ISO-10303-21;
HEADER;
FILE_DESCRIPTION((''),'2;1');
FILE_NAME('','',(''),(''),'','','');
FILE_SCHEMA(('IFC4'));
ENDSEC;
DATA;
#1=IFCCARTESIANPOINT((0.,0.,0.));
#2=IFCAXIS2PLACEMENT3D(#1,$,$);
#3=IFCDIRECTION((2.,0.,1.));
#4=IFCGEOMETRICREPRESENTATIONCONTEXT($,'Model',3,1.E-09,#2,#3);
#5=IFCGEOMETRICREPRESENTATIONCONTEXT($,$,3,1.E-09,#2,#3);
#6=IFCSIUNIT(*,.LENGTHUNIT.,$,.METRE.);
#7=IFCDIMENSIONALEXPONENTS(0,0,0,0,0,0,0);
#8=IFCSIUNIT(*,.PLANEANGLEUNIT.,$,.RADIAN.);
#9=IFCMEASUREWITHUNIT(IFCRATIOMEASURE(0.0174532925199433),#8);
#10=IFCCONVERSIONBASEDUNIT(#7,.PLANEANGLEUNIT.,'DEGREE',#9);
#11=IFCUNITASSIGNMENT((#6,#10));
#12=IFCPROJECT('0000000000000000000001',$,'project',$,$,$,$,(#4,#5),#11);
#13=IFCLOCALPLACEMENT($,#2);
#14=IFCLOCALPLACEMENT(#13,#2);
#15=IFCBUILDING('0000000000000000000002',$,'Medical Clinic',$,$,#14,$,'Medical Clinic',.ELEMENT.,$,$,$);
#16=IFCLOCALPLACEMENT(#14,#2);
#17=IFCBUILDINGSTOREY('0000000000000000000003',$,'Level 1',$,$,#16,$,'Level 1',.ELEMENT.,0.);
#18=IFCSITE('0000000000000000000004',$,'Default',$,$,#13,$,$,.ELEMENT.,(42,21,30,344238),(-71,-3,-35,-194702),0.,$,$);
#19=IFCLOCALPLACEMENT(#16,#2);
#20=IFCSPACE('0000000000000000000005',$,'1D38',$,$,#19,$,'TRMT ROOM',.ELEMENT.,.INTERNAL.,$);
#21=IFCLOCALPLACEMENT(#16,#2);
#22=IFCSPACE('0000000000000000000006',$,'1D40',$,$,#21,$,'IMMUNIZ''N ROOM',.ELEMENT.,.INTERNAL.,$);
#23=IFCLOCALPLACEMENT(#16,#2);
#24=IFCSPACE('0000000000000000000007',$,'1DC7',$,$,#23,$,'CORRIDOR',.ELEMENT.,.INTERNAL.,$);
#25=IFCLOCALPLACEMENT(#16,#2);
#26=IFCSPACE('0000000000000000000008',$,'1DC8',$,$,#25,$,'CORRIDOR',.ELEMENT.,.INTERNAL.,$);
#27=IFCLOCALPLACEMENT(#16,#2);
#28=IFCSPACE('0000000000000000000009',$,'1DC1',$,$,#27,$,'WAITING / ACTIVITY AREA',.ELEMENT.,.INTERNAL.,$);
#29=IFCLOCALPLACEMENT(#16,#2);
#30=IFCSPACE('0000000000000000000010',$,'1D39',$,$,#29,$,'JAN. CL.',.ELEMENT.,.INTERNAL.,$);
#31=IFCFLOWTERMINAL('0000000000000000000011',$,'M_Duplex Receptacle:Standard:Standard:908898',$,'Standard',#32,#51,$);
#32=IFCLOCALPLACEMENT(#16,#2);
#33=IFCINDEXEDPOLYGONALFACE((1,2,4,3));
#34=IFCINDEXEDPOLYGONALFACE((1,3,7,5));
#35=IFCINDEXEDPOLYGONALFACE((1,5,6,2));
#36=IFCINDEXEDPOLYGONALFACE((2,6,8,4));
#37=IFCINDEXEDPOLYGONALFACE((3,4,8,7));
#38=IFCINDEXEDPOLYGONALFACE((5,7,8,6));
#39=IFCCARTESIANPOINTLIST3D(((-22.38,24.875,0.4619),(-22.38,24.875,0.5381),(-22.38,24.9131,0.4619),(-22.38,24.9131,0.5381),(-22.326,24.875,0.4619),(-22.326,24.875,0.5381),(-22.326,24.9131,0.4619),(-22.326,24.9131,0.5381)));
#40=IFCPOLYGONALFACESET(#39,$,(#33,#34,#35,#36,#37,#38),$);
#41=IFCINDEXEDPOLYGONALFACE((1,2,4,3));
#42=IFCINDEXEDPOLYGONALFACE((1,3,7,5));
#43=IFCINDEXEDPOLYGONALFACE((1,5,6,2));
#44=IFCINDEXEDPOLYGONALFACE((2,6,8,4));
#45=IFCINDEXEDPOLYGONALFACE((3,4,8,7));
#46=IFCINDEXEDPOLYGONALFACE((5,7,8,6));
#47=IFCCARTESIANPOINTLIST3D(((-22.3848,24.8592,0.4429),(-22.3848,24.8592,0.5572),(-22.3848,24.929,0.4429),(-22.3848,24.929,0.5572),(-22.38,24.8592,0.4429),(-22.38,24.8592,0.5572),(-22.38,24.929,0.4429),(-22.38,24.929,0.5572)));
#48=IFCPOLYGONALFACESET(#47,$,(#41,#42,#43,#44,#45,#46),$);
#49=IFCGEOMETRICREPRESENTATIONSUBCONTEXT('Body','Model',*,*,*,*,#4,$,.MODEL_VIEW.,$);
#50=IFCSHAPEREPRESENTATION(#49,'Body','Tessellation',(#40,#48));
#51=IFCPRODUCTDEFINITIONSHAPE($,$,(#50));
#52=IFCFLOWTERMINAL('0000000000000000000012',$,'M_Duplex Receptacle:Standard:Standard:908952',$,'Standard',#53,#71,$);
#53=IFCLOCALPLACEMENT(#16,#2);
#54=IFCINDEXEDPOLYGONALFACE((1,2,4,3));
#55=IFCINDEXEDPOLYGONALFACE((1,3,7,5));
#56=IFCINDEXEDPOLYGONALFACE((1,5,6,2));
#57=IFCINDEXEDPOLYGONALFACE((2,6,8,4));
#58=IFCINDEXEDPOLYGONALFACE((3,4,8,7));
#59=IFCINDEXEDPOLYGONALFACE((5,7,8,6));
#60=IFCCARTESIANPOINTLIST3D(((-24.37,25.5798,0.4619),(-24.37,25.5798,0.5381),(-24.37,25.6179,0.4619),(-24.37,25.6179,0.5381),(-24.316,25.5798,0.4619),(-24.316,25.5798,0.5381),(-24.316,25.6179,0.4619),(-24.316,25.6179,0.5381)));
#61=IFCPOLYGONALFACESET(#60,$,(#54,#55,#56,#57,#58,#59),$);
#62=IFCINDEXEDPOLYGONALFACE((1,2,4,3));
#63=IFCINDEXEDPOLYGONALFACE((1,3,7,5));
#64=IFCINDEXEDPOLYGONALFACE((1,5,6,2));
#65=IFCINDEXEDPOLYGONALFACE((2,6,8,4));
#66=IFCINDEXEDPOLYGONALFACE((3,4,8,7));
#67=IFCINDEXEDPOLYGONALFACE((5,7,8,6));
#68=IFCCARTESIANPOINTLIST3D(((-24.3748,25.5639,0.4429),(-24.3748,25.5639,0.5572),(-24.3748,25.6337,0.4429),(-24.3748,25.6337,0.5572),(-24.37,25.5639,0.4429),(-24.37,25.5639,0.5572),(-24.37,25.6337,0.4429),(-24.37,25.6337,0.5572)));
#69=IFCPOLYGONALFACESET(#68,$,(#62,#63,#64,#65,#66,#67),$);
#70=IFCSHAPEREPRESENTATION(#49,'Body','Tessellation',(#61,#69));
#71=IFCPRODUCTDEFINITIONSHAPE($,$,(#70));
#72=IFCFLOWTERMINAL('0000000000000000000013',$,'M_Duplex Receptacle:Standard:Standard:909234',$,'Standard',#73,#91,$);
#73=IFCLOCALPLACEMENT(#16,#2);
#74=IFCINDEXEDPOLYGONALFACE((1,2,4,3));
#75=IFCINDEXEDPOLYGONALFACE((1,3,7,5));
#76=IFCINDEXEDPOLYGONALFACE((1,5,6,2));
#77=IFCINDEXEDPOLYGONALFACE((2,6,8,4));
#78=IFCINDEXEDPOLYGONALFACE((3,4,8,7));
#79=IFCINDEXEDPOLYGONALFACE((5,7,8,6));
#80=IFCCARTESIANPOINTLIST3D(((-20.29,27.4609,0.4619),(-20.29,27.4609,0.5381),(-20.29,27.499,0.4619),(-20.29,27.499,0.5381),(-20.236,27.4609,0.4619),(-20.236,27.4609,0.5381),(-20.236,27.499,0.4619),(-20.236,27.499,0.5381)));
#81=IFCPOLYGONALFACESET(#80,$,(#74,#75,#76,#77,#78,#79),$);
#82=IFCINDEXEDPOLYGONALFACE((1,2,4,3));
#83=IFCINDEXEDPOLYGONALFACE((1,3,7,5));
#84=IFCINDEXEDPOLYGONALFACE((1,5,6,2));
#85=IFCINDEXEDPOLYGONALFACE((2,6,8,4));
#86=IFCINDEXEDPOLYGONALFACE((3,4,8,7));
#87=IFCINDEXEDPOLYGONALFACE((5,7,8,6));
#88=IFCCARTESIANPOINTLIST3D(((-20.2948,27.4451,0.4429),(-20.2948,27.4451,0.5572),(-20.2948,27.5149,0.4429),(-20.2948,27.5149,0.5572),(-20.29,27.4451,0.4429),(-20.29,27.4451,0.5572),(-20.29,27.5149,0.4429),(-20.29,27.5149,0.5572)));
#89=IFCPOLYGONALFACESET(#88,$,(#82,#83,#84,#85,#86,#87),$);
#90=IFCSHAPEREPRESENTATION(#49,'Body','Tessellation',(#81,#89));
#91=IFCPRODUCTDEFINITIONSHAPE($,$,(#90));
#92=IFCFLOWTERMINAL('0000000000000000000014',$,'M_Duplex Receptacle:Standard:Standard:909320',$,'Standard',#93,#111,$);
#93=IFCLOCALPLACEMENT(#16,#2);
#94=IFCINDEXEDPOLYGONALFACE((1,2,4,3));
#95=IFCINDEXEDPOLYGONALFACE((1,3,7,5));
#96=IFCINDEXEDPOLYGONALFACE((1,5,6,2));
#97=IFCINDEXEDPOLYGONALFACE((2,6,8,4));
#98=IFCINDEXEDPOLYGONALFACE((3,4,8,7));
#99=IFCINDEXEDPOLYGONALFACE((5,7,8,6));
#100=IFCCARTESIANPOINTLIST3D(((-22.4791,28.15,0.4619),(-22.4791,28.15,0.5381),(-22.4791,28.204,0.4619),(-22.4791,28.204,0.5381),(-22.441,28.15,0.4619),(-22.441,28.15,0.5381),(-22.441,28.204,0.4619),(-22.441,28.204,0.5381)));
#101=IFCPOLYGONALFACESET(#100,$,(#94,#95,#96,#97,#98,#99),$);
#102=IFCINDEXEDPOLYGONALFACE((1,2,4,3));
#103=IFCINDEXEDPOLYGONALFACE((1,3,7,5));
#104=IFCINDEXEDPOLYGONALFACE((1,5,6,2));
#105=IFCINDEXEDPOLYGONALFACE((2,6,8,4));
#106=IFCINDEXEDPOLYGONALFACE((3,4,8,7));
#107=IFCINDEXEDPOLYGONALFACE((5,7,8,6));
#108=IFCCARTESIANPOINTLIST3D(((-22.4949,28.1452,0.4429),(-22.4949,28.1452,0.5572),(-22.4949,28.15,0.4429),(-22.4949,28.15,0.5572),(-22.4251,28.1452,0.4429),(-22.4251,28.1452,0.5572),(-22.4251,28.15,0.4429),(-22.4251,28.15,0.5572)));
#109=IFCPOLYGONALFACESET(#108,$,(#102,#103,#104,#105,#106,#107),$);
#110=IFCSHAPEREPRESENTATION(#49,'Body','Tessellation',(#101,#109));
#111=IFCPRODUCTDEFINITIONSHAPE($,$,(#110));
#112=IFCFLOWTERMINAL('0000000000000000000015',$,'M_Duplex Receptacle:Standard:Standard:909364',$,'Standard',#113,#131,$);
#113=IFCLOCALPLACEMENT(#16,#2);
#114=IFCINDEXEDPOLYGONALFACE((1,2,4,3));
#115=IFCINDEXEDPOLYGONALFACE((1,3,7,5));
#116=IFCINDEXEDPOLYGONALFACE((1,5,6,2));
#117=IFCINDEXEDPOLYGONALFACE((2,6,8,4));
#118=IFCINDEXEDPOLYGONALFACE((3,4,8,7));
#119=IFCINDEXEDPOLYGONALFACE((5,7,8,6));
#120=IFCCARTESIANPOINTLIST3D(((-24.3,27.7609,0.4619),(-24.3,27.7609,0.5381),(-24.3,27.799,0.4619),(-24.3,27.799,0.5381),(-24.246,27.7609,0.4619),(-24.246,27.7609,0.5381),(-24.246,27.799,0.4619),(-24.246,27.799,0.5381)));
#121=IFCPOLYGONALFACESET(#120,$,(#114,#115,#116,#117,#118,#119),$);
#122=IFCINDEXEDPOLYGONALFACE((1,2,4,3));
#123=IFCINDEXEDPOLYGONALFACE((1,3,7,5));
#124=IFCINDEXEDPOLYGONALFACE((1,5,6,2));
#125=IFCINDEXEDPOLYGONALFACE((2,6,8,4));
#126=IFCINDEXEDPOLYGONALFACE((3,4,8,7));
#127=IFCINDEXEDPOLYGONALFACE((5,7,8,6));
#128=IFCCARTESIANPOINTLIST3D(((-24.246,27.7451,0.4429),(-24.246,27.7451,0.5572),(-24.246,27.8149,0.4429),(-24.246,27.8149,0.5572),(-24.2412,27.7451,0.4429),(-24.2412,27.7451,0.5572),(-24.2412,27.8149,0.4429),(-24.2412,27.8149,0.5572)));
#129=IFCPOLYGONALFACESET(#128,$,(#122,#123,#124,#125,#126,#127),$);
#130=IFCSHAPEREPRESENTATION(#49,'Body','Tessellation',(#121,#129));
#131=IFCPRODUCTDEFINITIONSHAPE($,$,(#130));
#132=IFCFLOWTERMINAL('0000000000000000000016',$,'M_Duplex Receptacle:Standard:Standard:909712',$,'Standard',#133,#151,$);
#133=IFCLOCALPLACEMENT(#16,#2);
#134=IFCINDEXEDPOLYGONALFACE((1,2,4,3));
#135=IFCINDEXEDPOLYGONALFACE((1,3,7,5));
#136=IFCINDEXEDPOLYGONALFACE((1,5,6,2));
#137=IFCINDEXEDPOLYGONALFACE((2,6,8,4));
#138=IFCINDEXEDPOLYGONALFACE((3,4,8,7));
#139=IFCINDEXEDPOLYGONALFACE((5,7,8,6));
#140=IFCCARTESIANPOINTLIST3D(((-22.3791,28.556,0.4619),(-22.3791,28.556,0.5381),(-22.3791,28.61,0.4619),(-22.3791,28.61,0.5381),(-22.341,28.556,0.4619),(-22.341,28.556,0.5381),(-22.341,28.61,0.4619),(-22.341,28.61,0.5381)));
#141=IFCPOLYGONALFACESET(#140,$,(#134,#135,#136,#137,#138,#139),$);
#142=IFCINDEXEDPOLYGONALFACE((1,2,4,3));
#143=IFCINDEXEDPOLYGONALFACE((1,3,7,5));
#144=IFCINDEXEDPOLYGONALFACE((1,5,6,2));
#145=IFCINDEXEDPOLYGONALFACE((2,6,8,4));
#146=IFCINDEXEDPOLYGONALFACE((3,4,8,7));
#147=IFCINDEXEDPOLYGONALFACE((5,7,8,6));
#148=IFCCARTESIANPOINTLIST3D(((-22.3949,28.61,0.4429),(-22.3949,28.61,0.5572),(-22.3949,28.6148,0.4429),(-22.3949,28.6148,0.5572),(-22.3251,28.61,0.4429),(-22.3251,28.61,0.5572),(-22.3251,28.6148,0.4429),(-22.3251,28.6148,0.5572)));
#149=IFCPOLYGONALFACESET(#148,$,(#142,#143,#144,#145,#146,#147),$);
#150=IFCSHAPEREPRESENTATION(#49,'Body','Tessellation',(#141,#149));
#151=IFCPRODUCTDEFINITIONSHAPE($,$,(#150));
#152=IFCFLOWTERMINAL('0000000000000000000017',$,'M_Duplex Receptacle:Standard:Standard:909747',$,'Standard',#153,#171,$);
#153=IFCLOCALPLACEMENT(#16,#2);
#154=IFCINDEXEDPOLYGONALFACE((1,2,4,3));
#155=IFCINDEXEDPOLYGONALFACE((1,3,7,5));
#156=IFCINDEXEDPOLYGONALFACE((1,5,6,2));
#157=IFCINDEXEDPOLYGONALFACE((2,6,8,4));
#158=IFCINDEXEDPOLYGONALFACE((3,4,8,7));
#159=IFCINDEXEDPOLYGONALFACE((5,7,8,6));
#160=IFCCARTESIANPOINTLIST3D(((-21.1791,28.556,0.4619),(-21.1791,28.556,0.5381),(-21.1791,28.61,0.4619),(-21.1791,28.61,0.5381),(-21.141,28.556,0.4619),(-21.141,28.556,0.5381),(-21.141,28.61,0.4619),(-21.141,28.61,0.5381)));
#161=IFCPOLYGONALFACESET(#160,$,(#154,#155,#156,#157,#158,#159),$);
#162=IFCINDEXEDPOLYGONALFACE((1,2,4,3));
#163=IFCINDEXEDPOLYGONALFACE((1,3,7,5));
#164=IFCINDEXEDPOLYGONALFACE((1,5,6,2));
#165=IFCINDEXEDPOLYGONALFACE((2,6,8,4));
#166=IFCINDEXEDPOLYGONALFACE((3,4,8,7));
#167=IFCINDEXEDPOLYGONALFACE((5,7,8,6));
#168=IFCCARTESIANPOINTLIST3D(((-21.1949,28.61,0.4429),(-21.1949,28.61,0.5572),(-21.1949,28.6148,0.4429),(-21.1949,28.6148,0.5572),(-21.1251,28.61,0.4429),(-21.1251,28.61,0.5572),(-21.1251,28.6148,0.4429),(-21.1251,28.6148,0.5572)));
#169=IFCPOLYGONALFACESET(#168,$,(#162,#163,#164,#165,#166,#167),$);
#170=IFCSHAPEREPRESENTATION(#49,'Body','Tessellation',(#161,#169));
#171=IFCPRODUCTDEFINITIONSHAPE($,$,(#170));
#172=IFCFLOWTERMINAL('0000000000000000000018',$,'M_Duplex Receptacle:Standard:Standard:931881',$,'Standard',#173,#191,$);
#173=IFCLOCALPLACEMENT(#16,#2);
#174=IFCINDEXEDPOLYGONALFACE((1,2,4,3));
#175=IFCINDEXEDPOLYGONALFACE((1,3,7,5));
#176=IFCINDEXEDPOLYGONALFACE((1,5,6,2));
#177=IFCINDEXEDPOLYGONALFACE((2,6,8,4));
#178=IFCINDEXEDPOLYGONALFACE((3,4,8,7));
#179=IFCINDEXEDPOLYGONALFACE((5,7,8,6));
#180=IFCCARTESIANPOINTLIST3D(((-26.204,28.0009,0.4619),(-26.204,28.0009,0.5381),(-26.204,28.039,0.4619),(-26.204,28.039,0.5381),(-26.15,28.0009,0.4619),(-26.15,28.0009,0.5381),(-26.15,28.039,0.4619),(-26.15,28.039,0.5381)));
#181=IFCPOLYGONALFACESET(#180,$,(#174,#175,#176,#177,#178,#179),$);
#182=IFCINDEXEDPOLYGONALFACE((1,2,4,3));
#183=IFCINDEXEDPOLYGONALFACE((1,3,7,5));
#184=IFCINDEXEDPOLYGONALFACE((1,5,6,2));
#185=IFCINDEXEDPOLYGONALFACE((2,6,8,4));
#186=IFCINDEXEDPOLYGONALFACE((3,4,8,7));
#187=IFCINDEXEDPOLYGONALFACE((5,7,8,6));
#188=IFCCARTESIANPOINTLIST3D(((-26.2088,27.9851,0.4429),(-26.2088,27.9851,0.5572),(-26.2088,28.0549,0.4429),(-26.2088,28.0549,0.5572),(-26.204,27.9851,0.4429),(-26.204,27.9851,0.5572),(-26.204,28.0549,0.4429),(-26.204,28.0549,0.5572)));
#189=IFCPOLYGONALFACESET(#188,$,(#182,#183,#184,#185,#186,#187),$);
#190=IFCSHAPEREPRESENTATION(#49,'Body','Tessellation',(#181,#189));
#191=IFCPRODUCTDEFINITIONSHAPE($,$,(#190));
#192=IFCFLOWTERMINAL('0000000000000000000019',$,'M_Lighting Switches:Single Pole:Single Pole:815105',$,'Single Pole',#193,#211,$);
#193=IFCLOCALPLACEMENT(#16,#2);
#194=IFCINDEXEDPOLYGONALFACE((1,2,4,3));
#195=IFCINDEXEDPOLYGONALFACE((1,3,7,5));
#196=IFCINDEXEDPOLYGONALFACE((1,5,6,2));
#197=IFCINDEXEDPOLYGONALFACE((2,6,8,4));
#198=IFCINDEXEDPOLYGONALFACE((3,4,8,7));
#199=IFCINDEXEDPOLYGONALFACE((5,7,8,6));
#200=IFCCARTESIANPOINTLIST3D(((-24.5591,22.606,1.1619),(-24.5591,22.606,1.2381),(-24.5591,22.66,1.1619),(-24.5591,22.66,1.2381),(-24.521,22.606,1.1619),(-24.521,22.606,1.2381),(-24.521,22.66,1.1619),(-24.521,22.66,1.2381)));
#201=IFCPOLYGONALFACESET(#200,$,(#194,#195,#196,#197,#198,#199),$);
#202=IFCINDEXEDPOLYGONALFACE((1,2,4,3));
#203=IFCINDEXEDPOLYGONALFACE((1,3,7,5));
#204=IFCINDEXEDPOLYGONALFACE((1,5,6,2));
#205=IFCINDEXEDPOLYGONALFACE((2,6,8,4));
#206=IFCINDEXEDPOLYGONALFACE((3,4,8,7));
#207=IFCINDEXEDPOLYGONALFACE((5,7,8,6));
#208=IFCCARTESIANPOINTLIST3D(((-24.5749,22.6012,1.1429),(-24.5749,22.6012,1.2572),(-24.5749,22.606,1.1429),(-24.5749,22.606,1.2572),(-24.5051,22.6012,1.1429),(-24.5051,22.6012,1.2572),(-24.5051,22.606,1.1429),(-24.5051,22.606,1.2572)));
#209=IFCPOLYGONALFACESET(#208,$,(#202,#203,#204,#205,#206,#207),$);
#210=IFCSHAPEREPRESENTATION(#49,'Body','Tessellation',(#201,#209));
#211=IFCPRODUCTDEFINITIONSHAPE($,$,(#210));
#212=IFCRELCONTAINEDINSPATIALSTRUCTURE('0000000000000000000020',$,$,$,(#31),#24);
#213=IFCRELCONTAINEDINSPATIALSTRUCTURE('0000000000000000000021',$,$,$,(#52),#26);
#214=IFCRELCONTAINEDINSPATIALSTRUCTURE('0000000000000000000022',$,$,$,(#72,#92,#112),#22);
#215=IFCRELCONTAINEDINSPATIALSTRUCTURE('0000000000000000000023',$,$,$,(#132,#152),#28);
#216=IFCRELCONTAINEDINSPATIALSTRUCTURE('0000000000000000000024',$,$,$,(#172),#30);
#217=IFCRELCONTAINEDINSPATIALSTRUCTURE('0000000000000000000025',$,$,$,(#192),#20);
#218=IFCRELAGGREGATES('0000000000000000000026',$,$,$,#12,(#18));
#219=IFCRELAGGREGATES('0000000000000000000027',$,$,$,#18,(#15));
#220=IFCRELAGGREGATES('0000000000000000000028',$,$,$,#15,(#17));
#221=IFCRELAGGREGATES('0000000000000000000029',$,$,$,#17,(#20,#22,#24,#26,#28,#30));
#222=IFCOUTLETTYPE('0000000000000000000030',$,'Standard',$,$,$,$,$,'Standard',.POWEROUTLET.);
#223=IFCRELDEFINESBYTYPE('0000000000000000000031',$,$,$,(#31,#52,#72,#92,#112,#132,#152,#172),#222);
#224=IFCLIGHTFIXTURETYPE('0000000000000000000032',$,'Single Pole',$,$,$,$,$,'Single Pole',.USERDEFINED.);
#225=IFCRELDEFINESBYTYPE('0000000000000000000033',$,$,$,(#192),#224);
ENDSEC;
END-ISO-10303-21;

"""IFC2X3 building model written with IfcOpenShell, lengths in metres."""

from ifc_helpers import new_model, entity, si_unit, converted_unit, direction, frame, frame_2d, origin, origin_2d_with_axis, place, context, subcontext, project, spatial, rectangle, extrude, source, transform, mapped, type_object, type_shapes, element, save


model = new_model("IFC2X3")

# Units and contexts
model_context = context("Model", 3, precision=1e-09, world=origin(), true_north=direction((2.0, 0.0, 1.0)))
context_of_model = context(None, 3, precision=1e-09, world=origin(), true_north=direction((2.0, 0.0, 1.0)))
body_context = subcontext(model_context, "Body", "Model", "MODEL_VIEW")
ifc_project = project(units=[si_unit("LENGTHUNIT", "METRE"), converted_unit("PLANEANGLEUNIT", "DEGREE", entity("IfcRatioMeasure", 0.0174532925199433), si_unit("PLANEANGLEUNIT", "RADIAN"), dimensions=[0, 0, 0, 0, 0, 0, 0])], contexts=[model_context, context_of_model])

# Site, building, storey, space
site_placement = place(None, origin())
site = spatial("IfcSite", under=ifc_project, at=site_placement, Name="Default", CompositionType="ELEMENT", RefLatitude=(42, 21, 30, 344238), RefLongitude=(-71, -3, -35, -194702), RefElevation=0.0)
building_placement = place(site_placement, origin())
building = spatial("IfcBuilding", under=site, at=building_placement, Name="Medical Clinic", LongName="Medical Clinic", CompositionType="ELEMENT")
storey_placement = place(building_placement, origin())
storey = spatial("IfcBuildingStorey", under=building, at=storey_placement, Name="Level 1", LongName="Level 1", CompositionType="ELEMENT", Elevation=0.0)
space_1_placement = place(storey_placement, origin())
space_1 = spatial("IfcSpace", under=storey, at=space_1_placement, Name="1D38", LongName="TRMT ROOM", CompositionType="ELEMENT", InteriorOrExteriorSpace="INTERNAL")

# Shared definitions
outlet_type = type_object("IfcOutletType", Name="Standard", ElementType="Standard", PredefinedType="POWEROUTLET")
shared_shape_1 = source(origin(), body_context, "Body", "SweptSolid", [
    extrude(rectangle(XDim=0.0381, YDim=0.0762, at=origin_2d_with_axis()), frame((0.0, 0.0, -0.054), z_axis=(0.0, 0.0, 1.0), x_axis=(-1.0, 0.0, 0.0)), (0.0, 0.0, 1.0), 0.054),
    extrude(rectangle(XDim=0.0698, YDim=0.1143, at=frame_2d((0.0, 0.0), x_axis=(1.0, 0.0))), frame((0.0, 0.0, 0.0), z_axis=(0.0, 0.0, 1.0), x_axis=(-1.0, 0.0, 0.0)), (0.0, 0.0, 1.0), 0.0048),
])
type_shapes(outlet_type, [shared_shape_1])

# Shared definitions
space_2_placement = place(storey_placement, origin())
space_2 = spatial("IfcSpace", under=storey, at=space_2_placement, Name="1D40", LongName="IMMUNIZ'N ROOM", CompositionType="ELEMENT", InteriorOrExteriorSpace="INTERNAL")

# Shared definitions
space_3_placement = place(storey_placement, origin())
space_3 = spatial("IfcSpace", under=storey, at=space_3_placement, Name="1DC7", LongName="CORRIDOR", CompositionType="ELEMENT", InteriorOrExteriorSpace="INTERNAL")

# Flow terminal
flow_terminal_1_placement = place(space_3_placement, frame((-22.38, 24.8941, 0.5), z_axis=(-1.0, 0.0, 0.0), x_axis=(0.0, -1.0, 0.0)))
element("IfcFlowTerminal", 1, at=flow_terminal_1_placement, inside=space_3, type_object=outlet_type, Name="M_Duplex Receptacle:Standard:Standard:908898", ObjectType="Standard", context=body_context, shape_type="MappedRepresentation", body=[
    mapped(shared_shape_1, transform((0.0, 0.0, 0.0), scale=1.0)),
])

# Shared definitions
space_4_placement = place(storey_placement, origin())
space_4 = spatial("IfcSpace", under=storey, at=space_4_placement, Name="1DC8", LongName="CORRIDOR", CompositionType="ELEMENT", InteriorOrExteriorSpace="INTERNAL")

# Flow terminals
flow_terminal_2_placement = place(space_4_placement, frame((-24.37, 25.5988, 0.5), z_axis=(-1.0, 0.0, 0.0), x_axis=(0.0, -1.0, 0.0)))
element("IfcFlowTerminal", 2, at=flow_terminal_2_placement, inside=space_4, type_object=outlet_type, Name="M_Duplex Receptacle:Standard:Standard:908952", ObjectType="Standard", context=body_context, shape_type="MappedRepresentation", body=[
    mapped(shared_shape_1, transform((0.0, 0.0, 0.0), scale=1.0)),
])
for number, where, z_axis, x_axis, name in (
    (3, (-20.29, 27.48, 0.5), (-1.0, 0.0, 0.0), (0.0, -1.0, 0.0), "M_Duplex Receptacle:Standard:Standard:909234"),
    (4, (-22.46, 28.15, 0.5), (0.0, -1.0, 0.0), (1.0, 0.0, 0.0), "M_Duplex Receptacle:Standard:Standard:909320"),
    (5, (-24.246, 27.78, 0.5), (1.0, 0.0, 0.0), (0.0, 1.0, 0.0), "M_Duplex Receptacle:Standard:Standard:909364"),
):
    element("IfcFlowTerminal", number, at=place(space_2_placement, frame(where, z_axis=z_axis, x_axis=x_axis)), inside=space_2, type_object=outlet_type, Name=name, ObjectType="Standard", context=body_context, shape_type="MappedRepresentation", body=[
        mapped(shared_shape_1, transform((0.0, 0.0, 0.0), scale=1.0)),
    ])

# Shared definitions
space_5_placement = place(storey_placement, origin())
space_5 = spatial("IfcSpace", under=storey, at=space_5_placement, Name="1DC1", LongName="WAITING / ACTIVITY AREA", CompositionType="ELEMENT", InteriorOrExteriorSpace="INTERNAL")

# Flow terminals
for number, where, z_axis, x_axis, name in (
    (6, (-22.36, 28.61, 0.5), (0.0, 1.0, 0.0), (-1.0, 0.0, 0.0), "M_Duplex Receptacle:Standard:Standard:909712"),
    (7, (-21.16, 28.61, 0.5), (0.0, 1.0, 0.0), (-1.0, 0.0, 0.0), "M_Duplex Receptacle:Standard:Standard:909747"),
):
    element("IfcFlowTerminal", number, at=place(space_5_placement, frame(where, z_axis=z_axis, x_axis=x_axis)), inside=space_5, type_object=outlet_type, Name=name, ObjectType="Standard", context=body_context, shape_type="MappedRepresentation", body=[
        mapped(shared_shape_1, transform((0.0, 0.0, 0.0), scale=1.0)),
    ])

# Shared definitions
space_6_placement = place(storey_placement, origin())
space_6 = spatial("IfcSpace", under=storey, at=space_6_placement, Name="1D39", LongName="JAN. CL.", CompositionType="ELEMENT", InteriorOrExteriorSpace="INTERNAL")

# Flow terminals
flow_terminal_3_placement = place(space_6_placement, frame((-26.204, 28.02, 0.5), z_axis=(-1.0, 0.0, 0.0), x_axis=(0.0, -1.0, 0.0)))
element("IfcFlowTerminal", 8, at=flow_terminal_3_placement, inside=space_6, type_object=outlet_type, Name="M_Duplex Receptacle:Standard:Standard:931881", ObjectType="Standard", context=body_context, shape_type="MappedRepresentation", body=[
    mapped(shared_shape_1, transform((0.0, 0.0, 0.0), scale=1.0)),
])
light_fixture_type_1 = type_object("IfcLightFixtureType", Name="Single Pole", ElementType="Single Pole", PredefinedType="USERDEFINED")
shared_shape_2 = source(origin(), body_context, "Body", "SweptSolid", [
    extrude(rectangle(XDim=0.0381, YDim=0.0762, at=origin_2d_with_axis()), frame((0.0, 0.0, -0.054), z_axis=(0.0, 0.0, 1.0), x_axis=(-1.0, 0.0, 0.0)), (0.0, 0.0, 1.0), 0.054),
    extrude(rectangle(XDim=0.0698, YDim=0.1143, at=frame_2d((0.0, 0.0), x_axis=(1.0, 0.0))), frame((0.0, 0.0, 0.0), z_axis=(0.0, 0.0, 1.0), x_axis=(-1.0, 0.0, 0.0)), (0.0, 0.0, 1.0), 0.0048),
])
type_shapes(light_fixture_type_1, [shared_shape_2])
flow_terminal_4_placement = place(space_1_placement, frame((-24.54, 22.606, 1.2), z_axis=(0.0, -1.0, 0.0), x_axis=(1.0, 0.0, 0.0)))
element("IfcFlowTerminal", 9, at=flow_terminal_4_placement, inside=space_1, type_object=light_fixture_type_1, Name="M_Lighting Switches:Single Pole:Single Pole:815105", ObjectType="Single Pole", context=body_context, shape_type="MappedRepresentation", body=[
    mapped(shared_shape_2, transform((0.0, 0.0, 0.0), scale=1.0)),
])

save(model, "model.ifc")
